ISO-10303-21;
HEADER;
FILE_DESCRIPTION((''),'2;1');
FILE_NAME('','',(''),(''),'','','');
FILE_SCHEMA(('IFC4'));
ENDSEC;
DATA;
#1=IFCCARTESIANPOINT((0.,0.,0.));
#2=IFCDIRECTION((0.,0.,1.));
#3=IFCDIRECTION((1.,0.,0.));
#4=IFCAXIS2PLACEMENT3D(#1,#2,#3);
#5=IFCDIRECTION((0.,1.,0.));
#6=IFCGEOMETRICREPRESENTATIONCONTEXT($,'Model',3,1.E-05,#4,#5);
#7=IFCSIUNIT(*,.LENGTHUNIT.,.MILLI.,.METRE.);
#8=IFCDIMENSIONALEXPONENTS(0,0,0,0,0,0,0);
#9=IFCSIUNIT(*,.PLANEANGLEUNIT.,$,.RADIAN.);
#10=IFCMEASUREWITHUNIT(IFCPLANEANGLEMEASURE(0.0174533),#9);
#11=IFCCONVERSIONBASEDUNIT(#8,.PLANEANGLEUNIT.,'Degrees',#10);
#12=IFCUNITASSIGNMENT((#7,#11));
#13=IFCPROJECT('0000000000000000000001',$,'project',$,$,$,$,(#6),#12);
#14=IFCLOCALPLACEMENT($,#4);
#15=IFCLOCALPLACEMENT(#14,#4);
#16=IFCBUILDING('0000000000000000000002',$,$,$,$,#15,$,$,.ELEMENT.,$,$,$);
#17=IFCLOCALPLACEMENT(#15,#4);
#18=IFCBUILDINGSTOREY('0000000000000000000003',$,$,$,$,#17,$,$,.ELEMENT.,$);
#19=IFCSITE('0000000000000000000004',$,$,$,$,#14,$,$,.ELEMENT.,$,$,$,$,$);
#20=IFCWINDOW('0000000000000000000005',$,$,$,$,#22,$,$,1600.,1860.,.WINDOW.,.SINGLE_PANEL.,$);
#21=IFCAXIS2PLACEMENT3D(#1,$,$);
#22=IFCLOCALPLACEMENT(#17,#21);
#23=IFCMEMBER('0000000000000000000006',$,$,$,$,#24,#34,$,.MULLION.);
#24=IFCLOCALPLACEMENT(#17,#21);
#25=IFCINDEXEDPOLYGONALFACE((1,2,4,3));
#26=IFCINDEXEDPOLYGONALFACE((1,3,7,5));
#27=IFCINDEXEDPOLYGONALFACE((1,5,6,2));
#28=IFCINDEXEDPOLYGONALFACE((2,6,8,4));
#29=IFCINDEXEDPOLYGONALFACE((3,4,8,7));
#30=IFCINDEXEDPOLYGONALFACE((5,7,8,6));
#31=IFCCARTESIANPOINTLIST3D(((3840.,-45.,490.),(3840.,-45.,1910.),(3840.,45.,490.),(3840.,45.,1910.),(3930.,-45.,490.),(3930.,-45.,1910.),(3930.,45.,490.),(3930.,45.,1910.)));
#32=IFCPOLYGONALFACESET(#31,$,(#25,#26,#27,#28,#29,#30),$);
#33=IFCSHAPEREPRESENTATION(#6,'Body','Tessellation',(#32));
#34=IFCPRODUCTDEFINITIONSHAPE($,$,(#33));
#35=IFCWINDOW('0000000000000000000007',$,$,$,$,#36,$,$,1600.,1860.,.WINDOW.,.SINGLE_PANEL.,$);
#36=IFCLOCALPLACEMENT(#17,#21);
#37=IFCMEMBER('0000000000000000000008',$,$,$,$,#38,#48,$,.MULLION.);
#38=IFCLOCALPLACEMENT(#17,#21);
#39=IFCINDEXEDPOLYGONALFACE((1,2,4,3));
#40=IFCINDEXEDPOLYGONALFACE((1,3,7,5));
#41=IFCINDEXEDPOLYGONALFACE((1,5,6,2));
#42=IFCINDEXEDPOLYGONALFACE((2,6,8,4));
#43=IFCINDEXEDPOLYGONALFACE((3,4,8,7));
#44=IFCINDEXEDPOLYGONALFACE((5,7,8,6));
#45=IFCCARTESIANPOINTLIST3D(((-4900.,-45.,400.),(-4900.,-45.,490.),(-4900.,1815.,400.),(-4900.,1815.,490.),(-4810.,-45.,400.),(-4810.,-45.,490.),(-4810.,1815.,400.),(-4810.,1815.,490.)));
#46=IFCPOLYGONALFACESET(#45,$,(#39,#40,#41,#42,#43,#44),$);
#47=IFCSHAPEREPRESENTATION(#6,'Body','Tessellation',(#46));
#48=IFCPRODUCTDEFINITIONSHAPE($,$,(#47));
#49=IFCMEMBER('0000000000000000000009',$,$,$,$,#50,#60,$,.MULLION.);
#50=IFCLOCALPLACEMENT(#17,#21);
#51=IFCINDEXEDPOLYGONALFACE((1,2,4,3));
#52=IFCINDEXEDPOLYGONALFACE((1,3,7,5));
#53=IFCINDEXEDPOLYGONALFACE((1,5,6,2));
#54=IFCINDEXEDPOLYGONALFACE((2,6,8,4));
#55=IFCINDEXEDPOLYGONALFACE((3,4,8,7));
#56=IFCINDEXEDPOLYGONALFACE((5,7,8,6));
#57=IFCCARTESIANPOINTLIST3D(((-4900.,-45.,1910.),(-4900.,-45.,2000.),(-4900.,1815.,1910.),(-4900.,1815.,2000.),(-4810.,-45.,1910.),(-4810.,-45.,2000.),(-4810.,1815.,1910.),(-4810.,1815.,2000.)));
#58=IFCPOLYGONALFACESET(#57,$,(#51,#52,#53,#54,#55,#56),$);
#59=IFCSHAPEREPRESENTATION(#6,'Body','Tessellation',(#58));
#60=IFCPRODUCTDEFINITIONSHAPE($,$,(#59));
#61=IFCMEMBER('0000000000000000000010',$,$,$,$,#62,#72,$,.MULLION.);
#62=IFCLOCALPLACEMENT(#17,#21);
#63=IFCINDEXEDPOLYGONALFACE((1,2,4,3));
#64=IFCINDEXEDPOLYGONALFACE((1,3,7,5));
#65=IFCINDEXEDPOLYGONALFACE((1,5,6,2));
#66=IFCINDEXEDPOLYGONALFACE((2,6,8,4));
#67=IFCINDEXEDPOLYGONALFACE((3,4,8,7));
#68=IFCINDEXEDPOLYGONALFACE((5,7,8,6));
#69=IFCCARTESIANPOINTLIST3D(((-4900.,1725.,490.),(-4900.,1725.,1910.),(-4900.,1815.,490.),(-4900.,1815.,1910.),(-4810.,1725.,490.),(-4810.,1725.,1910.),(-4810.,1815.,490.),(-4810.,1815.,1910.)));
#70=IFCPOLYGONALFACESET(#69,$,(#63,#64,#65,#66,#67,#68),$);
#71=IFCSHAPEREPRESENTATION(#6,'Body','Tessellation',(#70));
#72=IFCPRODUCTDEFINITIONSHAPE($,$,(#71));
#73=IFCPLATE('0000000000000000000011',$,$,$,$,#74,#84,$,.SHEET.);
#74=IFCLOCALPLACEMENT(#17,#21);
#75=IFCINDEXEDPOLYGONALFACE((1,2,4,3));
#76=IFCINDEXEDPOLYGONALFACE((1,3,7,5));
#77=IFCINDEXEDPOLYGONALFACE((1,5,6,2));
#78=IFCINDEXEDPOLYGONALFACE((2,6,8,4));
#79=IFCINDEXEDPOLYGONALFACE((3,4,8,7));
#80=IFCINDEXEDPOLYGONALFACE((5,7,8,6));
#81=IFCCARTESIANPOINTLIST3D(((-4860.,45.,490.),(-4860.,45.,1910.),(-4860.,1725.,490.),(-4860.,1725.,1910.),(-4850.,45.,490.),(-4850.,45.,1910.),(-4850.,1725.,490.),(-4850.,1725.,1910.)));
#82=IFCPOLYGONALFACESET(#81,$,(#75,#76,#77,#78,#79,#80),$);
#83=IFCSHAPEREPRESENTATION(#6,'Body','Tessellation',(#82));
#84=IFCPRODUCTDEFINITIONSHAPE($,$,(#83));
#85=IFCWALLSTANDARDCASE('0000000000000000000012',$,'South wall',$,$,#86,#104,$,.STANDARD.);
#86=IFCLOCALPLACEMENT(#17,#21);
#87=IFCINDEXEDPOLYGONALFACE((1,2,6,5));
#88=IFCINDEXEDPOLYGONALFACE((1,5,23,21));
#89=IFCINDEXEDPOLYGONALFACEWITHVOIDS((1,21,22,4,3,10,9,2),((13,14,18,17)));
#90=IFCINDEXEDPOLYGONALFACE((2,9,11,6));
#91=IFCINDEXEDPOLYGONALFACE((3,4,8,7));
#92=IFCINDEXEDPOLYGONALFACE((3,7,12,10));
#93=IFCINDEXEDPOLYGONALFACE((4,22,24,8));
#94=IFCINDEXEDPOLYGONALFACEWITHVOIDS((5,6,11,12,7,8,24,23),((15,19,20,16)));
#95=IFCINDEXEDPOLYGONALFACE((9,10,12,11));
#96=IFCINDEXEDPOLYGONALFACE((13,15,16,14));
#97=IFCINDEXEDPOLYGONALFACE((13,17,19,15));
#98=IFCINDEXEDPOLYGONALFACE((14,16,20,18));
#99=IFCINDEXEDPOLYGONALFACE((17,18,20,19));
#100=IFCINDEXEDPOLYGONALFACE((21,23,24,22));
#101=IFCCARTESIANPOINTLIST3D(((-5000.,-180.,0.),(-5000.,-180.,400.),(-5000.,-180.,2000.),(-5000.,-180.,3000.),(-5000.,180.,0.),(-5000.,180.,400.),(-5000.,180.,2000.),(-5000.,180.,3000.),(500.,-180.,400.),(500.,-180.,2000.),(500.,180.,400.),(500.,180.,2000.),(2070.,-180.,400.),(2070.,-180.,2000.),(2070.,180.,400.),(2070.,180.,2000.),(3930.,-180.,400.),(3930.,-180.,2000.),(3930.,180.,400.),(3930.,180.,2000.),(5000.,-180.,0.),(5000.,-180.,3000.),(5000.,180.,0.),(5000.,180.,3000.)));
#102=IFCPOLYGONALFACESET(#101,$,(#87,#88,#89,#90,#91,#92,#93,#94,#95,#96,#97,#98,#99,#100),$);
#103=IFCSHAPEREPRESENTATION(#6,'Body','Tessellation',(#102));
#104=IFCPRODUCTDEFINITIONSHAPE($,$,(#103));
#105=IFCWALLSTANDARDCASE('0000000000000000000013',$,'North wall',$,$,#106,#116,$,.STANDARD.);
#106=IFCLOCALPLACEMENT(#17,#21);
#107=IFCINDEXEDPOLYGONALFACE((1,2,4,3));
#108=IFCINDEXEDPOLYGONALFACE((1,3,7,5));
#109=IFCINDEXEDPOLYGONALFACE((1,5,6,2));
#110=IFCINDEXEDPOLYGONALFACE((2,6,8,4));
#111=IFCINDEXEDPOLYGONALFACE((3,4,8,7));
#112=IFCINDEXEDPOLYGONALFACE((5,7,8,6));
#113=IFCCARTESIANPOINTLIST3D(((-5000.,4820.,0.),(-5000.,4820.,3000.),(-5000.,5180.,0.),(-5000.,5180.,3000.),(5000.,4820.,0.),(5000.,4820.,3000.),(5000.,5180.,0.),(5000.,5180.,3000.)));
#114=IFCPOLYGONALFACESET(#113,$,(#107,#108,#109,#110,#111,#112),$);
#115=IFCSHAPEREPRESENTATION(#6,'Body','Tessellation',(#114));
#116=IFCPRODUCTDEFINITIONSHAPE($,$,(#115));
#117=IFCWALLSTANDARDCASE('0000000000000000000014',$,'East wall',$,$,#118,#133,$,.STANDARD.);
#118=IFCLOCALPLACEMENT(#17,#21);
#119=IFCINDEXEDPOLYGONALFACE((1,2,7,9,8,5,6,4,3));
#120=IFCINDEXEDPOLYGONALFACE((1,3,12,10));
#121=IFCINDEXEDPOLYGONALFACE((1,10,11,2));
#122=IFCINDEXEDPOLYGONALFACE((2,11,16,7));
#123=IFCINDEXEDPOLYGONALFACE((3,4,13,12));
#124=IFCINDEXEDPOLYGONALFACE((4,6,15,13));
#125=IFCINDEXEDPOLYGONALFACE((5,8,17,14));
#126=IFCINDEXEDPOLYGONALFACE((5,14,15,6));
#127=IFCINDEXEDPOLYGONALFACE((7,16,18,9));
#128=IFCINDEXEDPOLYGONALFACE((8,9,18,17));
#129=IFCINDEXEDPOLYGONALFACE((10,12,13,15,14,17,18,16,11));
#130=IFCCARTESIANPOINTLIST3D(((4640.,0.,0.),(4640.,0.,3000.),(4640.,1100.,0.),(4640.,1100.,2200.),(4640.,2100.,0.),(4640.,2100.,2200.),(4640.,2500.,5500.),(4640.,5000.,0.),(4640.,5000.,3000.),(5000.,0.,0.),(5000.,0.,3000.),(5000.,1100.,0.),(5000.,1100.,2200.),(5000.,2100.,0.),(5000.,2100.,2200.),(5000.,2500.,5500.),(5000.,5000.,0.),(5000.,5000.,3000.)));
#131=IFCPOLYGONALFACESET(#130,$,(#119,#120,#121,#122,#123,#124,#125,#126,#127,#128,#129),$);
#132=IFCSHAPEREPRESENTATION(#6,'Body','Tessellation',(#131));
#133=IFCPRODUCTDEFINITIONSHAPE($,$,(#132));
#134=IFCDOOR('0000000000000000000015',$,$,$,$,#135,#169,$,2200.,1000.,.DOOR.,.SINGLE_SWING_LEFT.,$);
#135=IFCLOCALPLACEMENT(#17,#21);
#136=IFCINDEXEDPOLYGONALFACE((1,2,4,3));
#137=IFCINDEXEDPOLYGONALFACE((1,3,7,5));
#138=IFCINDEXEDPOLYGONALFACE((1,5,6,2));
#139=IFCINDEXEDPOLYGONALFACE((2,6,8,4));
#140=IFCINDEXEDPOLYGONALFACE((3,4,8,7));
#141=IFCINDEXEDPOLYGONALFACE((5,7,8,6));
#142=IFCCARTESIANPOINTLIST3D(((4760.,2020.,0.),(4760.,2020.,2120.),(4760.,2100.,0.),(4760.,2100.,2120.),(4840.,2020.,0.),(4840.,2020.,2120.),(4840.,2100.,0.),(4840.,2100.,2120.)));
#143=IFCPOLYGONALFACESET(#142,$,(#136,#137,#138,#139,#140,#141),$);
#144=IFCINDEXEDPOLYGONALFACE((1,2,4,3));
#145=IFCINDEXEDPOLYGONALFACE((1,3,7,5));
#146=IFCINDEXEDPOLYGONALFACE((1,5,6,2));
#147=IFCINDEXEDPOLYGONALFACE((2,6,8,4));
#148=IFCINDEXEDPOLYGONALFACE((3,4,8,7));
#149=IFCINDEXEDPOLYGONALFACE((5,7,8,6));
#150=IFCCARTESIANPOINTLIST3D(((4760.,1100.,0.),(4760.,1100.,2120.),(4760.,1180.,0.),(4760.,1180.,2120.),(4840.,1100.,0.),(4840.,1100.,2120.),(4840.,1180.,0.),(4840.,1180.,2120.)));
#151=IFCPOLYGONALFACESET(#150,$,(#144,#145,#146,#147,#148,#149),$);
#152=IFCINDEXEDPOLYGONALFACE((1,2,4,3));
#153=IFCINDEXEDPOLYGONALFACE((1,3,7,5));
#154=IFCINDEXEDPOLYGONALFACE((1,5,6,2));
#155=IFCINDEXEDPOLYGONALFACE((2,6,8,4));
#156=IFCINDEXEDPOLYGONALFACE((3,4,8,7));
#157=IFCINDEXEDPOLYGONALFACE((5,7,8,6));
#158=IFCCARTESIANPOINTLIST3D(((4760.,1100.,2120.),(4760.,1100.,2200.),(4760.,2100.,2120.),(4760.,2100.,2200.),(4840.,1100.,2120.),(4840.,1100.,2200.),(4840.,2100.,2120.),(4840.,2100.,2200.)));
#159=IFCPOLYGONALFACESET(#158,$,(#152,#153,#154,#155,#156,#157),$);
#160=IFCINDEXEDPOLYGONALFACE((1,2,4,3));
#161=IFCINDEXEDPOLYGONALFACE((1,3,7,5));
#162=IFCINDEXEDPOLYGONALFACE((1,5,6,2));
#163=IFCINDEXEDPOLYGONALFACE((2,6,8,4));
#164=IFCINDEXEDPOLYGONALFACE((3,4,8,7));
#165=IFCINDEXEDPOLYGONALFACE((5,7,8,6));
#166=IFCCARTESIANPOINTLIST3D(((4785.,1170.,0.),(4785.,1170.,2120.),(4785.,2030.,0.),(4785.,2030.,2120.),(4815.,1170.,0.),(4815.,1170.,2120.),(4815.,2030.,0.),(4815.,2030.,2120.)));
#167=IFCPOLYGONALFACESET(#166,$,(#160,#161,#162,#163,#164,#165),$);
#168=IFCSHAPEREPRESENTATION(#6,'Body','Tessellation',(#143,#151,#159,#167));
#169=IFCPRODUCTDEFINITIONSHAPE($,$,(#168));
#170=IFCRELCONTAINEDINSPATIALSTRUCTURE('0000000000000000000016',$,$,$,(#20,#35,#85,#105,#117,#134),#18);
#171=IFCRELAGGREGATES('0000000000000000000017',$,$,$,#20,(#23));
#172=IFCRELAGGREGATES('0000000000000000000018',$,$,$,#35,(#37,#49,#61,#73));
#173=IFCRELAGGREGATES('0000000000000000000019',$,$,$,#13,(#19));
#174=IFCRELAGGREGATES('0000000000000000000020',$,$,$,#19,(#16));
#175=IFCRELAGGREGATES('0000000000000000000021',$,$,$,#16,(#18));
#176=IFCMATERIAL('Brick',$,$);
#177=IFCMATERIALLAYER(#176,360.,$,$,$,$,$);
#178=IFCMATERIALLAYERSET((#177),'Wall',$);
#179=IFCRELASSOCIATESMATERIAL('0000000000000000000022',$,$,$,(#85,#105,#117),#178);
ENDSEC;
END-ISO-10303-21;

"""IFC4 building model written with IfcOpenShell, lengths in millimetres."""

from ifc_helpers import new_model, entity, si_unit, converted_unit, direction, frame, origin_with_axes, place, context, project, spatial, polyline, outline, extrude, clip, halfspace, material, layer, layer_set, layer_usage, element, fill, aggregate, save


model = new_model("IFC4")

# Units and contexts
model_context = context("Model", 3, precision=1e-05, world=origin_with_axes(), true_north=direction((0.0, 1.0, 0.0)))
ifc_project = project(units=[si_unit("LENGTHUNIT", "METRE", prefix="MILLI"), converted_unit("PLANEANGLEUNIT", "Degrees", entity("IfcPlaneAngleMeasure", 0.0174533), si_unit("PLANEANGLEUNIT", "RADIAN"), dimensions=[0, 0, 0, 0, 0, 0, 0])], contexts=[model_context])

# Site, building, storey
site_placement = place(None, origin_with_axes())
site = spatial("IfcSite", under=ifc_project, at=site_placement, CompositionType="ELEMENT")
building_placement = place(site_placement, origin_with_axes())
building = spatial("IfcBuilding", under=site, at=building_placement, CompositionType="ELEMENT")
storey_placement = place(building_placement, origin_with_axes())
storey = spatial("IfcBuildingStorey", under=building, at=storey_placement, CompositionType="ELEMENT")

# Windows, members
window_1_placement = place(storey_placement, frame((2070.0, -45.0, 400.0), z_axis=(0.0, 0.0, 1.0), x_axis=(1.0, 0.0, 0.0)))
window_1 = element("IfcWindow", 1, at=window_1_placement, inside=storey, OverallHeight=1600.0, OverallWidth=1860.0, PartitioningType="SINGLE_PANEL", PredefinedType="WINDOW")
member_1_placement = place(window_1_placement, frame((1815.0, 45.0, 90.0), z_axis=(0.0, 0.0, 1.0), x_axis=(1.0, 0.0, 0.0)))
member_1 = element("IfcMember", 2, at=member_1_placement, PredefinedType="MULLION", context=model_context, shape_type="SweptSolid", body=[
    extrude(outline(polyline([(-45.0, -45.0), (45.0, -45.0), (45.0, 45.0), (-45.0, 45.0), (-45.0, -45.0), (-45.0, -45.0)])), origin_with_axes(), (0.0, 0.0, 1.0), 1420.0),
])
window_2_placement = place(storey_placement, frame((-4810.0, -45.0, 400.0), z_axis=(0.0, 0.0, 1.0), x_axis=(0.0, 1.0, 0.0)))
window_2 = element("IfcWindow", 3, at=window_2_placement, inside=storey, OverallHeight=1600.0, OverallWidth=1860.0, PartitioningType="SINGLE_PANEL", PredefinedType="WINDOW")
member_2_placement = place(window_2_placement, frame((930.0, 45.0, 0.0), z_axis=(0.0, 0.0, 1.0), x_axis=(1.0, 0.0, 0.0)))
member_2 = element("IfcMember", 4, at=member_2_placement, PredefinedType="MULLION", context=model_context, shape_type="SweptSolid", body=[
    extrude(outline(polyline([(-930.0, -45.0), (930.0, -45.0), (930.0, 45.0), (-930.0, 45.0), (-930.0, -45.0), (-930.0, -45.0)])), origin_with_axes(), (0.0, 0.0, 1.0), 90.0),
])
member_3_placement = place(window_2_placement, frame((930.0, 45.0, 1510.0), z_axis=(0.0, 0.0, 1.0), x_axis=(1.0, 0.0, 0.0)))
member_3 = element("IfcMember", 5, at=member_3_placement, PredefinedType="MULLION", context=model_context, shape_type="SweptSolid", body=[
    extrude(outline(polyline([(-930.0, -45.0), (930.0, -45.0), (930.0, 45.0), (-930.0, 45.0), (-930.0, -45.0), (-930.0, -45.0)])), origin_with_axes(), (0.0, 0.0, 1.0), 90.0),
])
member_4_placement = place(window_2_placement, frame((1815.0, 45.0, 90.0), z_axis=(0.0, 0.0, 1.0), x_axis=(1.0, 0.0, 0.0)))
member_4 = element("IfcMember", 6, at=member_4_placement, PredefinedType="MULLION", context=model_context, shape_type="SweptSolid", body=[
    extrude(outline(polyline([(-45.0, -45.0), (45.0, -45.0), (45.0, 45.0), (-45.0, 45.0), (-45.0, -45.0), (-45.0, -45.0)])), origin_with_axes(), (0.0, 0.0, 1.0), 1420.0),
])

# Plate
aggregate(window_1, [member_1])
plate_1_placement = place(window_2_placement, frame((930.0, 45.0, 90.0), z_axis=(0.0, 0.0, 1.0), x_axis=(1.0, 0.0, 0.0)))
plate_1 = element("IfcPlate", 7, at=plate_1_placement, PredefinedType="SHEET", context=model_context, shape_type="SweptSolid", body=[
    extrude(outline(polyline([(-840.0, -5.0), (840.0, -5.0), (840.0, 5.0), (-840.0, 5.0), (-840.0, -5.0), (-840.0, -5.0)])), origin_with_axes(), (0.0, 0.0, 1.0), 1420.0),
])
aggregate(window_2, [member_2, member_3, member_4, plate_1])

# Wall, openings
ifc_material = material(Name="Brick")
ifc_layer = layer(ifc_material, 360.0)
ifc_layer_set = layer_set([ifc_layer], Name="Wall")
ifc_layer_usage = layer_usage(ifc_layer_set, "AXIS2", "POSITIVE", -180.0)
wall_1_placement = place(None, origin_with_axes())
wall_1 = element("IfcWallStandardCase", 8, at=wall_1_placement, inside=storey, material=ifc_layer_usage, Name="South wall", PredefinedType="STANDARD", context=model_context, shape_type="SweptSolid", body=[
    extrude(outline(polyline([(-5000.0, -180.0), (5000.0, -180.0), (5000.0, 180.0), (-5000.0, 180.0), (-5000.0, -180.0), (-5000.0, -180.0)])), origin_with_axes(), (0.0, 0.0, 1.0), 3000.0),
])
placement = place(None, frame((-2500.0, 0.0, 400.0), z_axis=(0.0, 0.0, 1.0), x_axis=(1.0, 0.0, 0.0)))
element("IfcOpeningElement", 9, at=placement, cuts=wall_1, PredefinedType="OPENING", context=model_context, shape_type="SweptSolid", body=[
    extrude(outline(polyline([(-3000.0, -1815.0), (3000.0, -1815.0), (3000.0, 1815.0), (-3000.0, 1815.0), (-3000.0, -1815.0), (-3000.0, -1815.0)])), origin_with_axes(), (0.0, 0.0, 1.0), 1600.0),
])
opening_1_placement = place(None, frame((3000.0, 0.0, 400.0), z_axis=(0.0, 0.0, 1.0), x_axis=(1.0, 0.0, 0.0)))
element("IfcOpeningElement", 10, at=opening_1_placement, cuts=wall_1, PredefinedType="OPENING", context=model_context, shape_type="SweptSolid", body=[
    extrude(outline(polyline([(-930.0, -1500.0), (930.0, -1500.0), (930.0, 1500.0), (-930.0, 1500.0), (-930.0, -1500.0), (-930.0, -1500.0)])), origin_with_axes(), (0.0, 0.0, 1.0), 1600.0),
])

# Wall
wall_2_placement = place(storey_placement, frame((0.0, 5000.0, 0.0), z_axis=(0.0, 0.0, 1.0), x_axis=(1.0, 0.0, 0.0)))
element("IfcWallStandardCase", 11, at=wall_2_placement, inside=storey, material=ifc_layer_usage, Name="North wall", PredefinedType="STANDARD", context=model_context, shape_type="SweptSolid", body=[
    extrude(outline(polyline([(-5000.0, -180.0), (5000.0, -180.0), (5000.0, 180.0), (-5000.0, 180.0), (-5000.0, -180.0), (-5000.0, -180.0)])), origin_with_axes(), (0.0, 0.0, 1.0), 3000.0),
])

# Wall, opening, door
wall_3_placement = place(storey_placement, frame((4820.0, 2500.0, 0.0), z_axis=(0.0, 0.0, 1.0), x_axis=(0.0, 1.0, 0.0)))
wall_3 = element("IfcWallStandardCase", 12, at=wall_3_placement, inside=storey, material=ifc_layer_usage, Name="East wall", PredefinedType="STANDARD", context=model_context, shape_type="Clipping", body=[
    clip(clip(extrude(outline(polyline([(-2500.0, -180.0), (2500.0, -180.0), (2500.0, 180.0), (-2500.0, 180.0), (-2500.0, -180.0), (-2500.0, -180.0)])), origin_with_axes(), (0.0, 0.0, 1.0), 6000.0), halfspace(frame((-2500.0, 0.0, 3000.0), z_axis=(-1.0, 0.0, 1.0), x_axis=(1.0, 0.0, 0.0)), False)), halfspace(frame((2500.0, 0.0, 3000.0), z_axis=(1.0, 0.0, 1.0), x_axis=(1.0, 0.0, 0.0)), False)),
])
opening_2_placement = place(None, frame((4820.0, 1600.0, 0.0), z_axis=(0.0, 0.0, 1.0), x_axis=(1.0, 0.0, 0.0)))
opening_2 = element("IfcOpeningElement", 13, at=opening_2_placement, cuts=wall_3, PredefinedType="OPENING", context=model_context, shape_type="SweptSolid", body=[
    extrude(outline(polyline([(-500.0, -500.0), (500.0, -500.0), (500.0, 500.0), (-500.0, 500.0), (-500.0, -500.0), (-500.0, -500.0)])), origin_with_axes(), (0.0, 0.0, 1.0), 2200.0),
])
door_placement = place(storey_placement, frame((4800.0, 1600.0, 0.0), z_axis=(0.0, 0.0, 1.0), x_axis=(0.0, 1.0, 0.0)))
door = element("IfcDoor", 14, at=door_placement, inside=storey, OperationType="SINGLE_SWING_LEFT", OverallHeight=2200.0, OverallWidth=1000.0, PredefinedType="DOOR", context=model_context, shape_type="SweptSolid", body=[
    extrude(outline(polyline([(-40.0, -40.0), (40.0, -40.0), (40.0, 40.0), (-40.0, 40.0), (-40.0, -40.0), (-40.0, -40.0)])), frame((460.0, 0.0, 0.0), z_axis=(0.0, 0.0, 1.0), x_axis=(1.0, 0.0, 0.0)), (0.0, 0.0, 1.0), 2120.0),
    extrude(outline(polyline([(-40.0, -40.0), (40.0, -40.0), (40.0, 40.0), (-40.0, 40.0), (-40.0, -40.0), (-40.0, -40.0)])), frame((-460.0, 0.0, 0.0), z_axis=(0.0, 0.0, 1.0), x_axis=(1.0, 0.0, 0.0)), (0.0, 0.0, 1.0), 2120.0),
    extrude(outline(polyline([(-500.0, -40.0), (500.0, -40.0), (500.0, 40.0), (-500.0, 40.0), (-500.0, -40.0), (-500.0, -40.0)])), frame((0.0, 0.0, 2120.0), z_axis=(0.0, 0.0, 1.0), x_axis=(1.0, 0.0, 0.0)), (0.0, 0.0, 1.0), 80.0),
    extrude(outline(polyline([(-430.0, -15.0), (430.0, -15.0), (430.0, 15.0), (-430.0, 15.0), (-430.0, -15.0), (-430.0, -15.0)])), origin_with_axes(), (0.0, 0.0, 1.0), 2120.0),
])
fill(opening_2, door)

save(model, "model.ifc")
